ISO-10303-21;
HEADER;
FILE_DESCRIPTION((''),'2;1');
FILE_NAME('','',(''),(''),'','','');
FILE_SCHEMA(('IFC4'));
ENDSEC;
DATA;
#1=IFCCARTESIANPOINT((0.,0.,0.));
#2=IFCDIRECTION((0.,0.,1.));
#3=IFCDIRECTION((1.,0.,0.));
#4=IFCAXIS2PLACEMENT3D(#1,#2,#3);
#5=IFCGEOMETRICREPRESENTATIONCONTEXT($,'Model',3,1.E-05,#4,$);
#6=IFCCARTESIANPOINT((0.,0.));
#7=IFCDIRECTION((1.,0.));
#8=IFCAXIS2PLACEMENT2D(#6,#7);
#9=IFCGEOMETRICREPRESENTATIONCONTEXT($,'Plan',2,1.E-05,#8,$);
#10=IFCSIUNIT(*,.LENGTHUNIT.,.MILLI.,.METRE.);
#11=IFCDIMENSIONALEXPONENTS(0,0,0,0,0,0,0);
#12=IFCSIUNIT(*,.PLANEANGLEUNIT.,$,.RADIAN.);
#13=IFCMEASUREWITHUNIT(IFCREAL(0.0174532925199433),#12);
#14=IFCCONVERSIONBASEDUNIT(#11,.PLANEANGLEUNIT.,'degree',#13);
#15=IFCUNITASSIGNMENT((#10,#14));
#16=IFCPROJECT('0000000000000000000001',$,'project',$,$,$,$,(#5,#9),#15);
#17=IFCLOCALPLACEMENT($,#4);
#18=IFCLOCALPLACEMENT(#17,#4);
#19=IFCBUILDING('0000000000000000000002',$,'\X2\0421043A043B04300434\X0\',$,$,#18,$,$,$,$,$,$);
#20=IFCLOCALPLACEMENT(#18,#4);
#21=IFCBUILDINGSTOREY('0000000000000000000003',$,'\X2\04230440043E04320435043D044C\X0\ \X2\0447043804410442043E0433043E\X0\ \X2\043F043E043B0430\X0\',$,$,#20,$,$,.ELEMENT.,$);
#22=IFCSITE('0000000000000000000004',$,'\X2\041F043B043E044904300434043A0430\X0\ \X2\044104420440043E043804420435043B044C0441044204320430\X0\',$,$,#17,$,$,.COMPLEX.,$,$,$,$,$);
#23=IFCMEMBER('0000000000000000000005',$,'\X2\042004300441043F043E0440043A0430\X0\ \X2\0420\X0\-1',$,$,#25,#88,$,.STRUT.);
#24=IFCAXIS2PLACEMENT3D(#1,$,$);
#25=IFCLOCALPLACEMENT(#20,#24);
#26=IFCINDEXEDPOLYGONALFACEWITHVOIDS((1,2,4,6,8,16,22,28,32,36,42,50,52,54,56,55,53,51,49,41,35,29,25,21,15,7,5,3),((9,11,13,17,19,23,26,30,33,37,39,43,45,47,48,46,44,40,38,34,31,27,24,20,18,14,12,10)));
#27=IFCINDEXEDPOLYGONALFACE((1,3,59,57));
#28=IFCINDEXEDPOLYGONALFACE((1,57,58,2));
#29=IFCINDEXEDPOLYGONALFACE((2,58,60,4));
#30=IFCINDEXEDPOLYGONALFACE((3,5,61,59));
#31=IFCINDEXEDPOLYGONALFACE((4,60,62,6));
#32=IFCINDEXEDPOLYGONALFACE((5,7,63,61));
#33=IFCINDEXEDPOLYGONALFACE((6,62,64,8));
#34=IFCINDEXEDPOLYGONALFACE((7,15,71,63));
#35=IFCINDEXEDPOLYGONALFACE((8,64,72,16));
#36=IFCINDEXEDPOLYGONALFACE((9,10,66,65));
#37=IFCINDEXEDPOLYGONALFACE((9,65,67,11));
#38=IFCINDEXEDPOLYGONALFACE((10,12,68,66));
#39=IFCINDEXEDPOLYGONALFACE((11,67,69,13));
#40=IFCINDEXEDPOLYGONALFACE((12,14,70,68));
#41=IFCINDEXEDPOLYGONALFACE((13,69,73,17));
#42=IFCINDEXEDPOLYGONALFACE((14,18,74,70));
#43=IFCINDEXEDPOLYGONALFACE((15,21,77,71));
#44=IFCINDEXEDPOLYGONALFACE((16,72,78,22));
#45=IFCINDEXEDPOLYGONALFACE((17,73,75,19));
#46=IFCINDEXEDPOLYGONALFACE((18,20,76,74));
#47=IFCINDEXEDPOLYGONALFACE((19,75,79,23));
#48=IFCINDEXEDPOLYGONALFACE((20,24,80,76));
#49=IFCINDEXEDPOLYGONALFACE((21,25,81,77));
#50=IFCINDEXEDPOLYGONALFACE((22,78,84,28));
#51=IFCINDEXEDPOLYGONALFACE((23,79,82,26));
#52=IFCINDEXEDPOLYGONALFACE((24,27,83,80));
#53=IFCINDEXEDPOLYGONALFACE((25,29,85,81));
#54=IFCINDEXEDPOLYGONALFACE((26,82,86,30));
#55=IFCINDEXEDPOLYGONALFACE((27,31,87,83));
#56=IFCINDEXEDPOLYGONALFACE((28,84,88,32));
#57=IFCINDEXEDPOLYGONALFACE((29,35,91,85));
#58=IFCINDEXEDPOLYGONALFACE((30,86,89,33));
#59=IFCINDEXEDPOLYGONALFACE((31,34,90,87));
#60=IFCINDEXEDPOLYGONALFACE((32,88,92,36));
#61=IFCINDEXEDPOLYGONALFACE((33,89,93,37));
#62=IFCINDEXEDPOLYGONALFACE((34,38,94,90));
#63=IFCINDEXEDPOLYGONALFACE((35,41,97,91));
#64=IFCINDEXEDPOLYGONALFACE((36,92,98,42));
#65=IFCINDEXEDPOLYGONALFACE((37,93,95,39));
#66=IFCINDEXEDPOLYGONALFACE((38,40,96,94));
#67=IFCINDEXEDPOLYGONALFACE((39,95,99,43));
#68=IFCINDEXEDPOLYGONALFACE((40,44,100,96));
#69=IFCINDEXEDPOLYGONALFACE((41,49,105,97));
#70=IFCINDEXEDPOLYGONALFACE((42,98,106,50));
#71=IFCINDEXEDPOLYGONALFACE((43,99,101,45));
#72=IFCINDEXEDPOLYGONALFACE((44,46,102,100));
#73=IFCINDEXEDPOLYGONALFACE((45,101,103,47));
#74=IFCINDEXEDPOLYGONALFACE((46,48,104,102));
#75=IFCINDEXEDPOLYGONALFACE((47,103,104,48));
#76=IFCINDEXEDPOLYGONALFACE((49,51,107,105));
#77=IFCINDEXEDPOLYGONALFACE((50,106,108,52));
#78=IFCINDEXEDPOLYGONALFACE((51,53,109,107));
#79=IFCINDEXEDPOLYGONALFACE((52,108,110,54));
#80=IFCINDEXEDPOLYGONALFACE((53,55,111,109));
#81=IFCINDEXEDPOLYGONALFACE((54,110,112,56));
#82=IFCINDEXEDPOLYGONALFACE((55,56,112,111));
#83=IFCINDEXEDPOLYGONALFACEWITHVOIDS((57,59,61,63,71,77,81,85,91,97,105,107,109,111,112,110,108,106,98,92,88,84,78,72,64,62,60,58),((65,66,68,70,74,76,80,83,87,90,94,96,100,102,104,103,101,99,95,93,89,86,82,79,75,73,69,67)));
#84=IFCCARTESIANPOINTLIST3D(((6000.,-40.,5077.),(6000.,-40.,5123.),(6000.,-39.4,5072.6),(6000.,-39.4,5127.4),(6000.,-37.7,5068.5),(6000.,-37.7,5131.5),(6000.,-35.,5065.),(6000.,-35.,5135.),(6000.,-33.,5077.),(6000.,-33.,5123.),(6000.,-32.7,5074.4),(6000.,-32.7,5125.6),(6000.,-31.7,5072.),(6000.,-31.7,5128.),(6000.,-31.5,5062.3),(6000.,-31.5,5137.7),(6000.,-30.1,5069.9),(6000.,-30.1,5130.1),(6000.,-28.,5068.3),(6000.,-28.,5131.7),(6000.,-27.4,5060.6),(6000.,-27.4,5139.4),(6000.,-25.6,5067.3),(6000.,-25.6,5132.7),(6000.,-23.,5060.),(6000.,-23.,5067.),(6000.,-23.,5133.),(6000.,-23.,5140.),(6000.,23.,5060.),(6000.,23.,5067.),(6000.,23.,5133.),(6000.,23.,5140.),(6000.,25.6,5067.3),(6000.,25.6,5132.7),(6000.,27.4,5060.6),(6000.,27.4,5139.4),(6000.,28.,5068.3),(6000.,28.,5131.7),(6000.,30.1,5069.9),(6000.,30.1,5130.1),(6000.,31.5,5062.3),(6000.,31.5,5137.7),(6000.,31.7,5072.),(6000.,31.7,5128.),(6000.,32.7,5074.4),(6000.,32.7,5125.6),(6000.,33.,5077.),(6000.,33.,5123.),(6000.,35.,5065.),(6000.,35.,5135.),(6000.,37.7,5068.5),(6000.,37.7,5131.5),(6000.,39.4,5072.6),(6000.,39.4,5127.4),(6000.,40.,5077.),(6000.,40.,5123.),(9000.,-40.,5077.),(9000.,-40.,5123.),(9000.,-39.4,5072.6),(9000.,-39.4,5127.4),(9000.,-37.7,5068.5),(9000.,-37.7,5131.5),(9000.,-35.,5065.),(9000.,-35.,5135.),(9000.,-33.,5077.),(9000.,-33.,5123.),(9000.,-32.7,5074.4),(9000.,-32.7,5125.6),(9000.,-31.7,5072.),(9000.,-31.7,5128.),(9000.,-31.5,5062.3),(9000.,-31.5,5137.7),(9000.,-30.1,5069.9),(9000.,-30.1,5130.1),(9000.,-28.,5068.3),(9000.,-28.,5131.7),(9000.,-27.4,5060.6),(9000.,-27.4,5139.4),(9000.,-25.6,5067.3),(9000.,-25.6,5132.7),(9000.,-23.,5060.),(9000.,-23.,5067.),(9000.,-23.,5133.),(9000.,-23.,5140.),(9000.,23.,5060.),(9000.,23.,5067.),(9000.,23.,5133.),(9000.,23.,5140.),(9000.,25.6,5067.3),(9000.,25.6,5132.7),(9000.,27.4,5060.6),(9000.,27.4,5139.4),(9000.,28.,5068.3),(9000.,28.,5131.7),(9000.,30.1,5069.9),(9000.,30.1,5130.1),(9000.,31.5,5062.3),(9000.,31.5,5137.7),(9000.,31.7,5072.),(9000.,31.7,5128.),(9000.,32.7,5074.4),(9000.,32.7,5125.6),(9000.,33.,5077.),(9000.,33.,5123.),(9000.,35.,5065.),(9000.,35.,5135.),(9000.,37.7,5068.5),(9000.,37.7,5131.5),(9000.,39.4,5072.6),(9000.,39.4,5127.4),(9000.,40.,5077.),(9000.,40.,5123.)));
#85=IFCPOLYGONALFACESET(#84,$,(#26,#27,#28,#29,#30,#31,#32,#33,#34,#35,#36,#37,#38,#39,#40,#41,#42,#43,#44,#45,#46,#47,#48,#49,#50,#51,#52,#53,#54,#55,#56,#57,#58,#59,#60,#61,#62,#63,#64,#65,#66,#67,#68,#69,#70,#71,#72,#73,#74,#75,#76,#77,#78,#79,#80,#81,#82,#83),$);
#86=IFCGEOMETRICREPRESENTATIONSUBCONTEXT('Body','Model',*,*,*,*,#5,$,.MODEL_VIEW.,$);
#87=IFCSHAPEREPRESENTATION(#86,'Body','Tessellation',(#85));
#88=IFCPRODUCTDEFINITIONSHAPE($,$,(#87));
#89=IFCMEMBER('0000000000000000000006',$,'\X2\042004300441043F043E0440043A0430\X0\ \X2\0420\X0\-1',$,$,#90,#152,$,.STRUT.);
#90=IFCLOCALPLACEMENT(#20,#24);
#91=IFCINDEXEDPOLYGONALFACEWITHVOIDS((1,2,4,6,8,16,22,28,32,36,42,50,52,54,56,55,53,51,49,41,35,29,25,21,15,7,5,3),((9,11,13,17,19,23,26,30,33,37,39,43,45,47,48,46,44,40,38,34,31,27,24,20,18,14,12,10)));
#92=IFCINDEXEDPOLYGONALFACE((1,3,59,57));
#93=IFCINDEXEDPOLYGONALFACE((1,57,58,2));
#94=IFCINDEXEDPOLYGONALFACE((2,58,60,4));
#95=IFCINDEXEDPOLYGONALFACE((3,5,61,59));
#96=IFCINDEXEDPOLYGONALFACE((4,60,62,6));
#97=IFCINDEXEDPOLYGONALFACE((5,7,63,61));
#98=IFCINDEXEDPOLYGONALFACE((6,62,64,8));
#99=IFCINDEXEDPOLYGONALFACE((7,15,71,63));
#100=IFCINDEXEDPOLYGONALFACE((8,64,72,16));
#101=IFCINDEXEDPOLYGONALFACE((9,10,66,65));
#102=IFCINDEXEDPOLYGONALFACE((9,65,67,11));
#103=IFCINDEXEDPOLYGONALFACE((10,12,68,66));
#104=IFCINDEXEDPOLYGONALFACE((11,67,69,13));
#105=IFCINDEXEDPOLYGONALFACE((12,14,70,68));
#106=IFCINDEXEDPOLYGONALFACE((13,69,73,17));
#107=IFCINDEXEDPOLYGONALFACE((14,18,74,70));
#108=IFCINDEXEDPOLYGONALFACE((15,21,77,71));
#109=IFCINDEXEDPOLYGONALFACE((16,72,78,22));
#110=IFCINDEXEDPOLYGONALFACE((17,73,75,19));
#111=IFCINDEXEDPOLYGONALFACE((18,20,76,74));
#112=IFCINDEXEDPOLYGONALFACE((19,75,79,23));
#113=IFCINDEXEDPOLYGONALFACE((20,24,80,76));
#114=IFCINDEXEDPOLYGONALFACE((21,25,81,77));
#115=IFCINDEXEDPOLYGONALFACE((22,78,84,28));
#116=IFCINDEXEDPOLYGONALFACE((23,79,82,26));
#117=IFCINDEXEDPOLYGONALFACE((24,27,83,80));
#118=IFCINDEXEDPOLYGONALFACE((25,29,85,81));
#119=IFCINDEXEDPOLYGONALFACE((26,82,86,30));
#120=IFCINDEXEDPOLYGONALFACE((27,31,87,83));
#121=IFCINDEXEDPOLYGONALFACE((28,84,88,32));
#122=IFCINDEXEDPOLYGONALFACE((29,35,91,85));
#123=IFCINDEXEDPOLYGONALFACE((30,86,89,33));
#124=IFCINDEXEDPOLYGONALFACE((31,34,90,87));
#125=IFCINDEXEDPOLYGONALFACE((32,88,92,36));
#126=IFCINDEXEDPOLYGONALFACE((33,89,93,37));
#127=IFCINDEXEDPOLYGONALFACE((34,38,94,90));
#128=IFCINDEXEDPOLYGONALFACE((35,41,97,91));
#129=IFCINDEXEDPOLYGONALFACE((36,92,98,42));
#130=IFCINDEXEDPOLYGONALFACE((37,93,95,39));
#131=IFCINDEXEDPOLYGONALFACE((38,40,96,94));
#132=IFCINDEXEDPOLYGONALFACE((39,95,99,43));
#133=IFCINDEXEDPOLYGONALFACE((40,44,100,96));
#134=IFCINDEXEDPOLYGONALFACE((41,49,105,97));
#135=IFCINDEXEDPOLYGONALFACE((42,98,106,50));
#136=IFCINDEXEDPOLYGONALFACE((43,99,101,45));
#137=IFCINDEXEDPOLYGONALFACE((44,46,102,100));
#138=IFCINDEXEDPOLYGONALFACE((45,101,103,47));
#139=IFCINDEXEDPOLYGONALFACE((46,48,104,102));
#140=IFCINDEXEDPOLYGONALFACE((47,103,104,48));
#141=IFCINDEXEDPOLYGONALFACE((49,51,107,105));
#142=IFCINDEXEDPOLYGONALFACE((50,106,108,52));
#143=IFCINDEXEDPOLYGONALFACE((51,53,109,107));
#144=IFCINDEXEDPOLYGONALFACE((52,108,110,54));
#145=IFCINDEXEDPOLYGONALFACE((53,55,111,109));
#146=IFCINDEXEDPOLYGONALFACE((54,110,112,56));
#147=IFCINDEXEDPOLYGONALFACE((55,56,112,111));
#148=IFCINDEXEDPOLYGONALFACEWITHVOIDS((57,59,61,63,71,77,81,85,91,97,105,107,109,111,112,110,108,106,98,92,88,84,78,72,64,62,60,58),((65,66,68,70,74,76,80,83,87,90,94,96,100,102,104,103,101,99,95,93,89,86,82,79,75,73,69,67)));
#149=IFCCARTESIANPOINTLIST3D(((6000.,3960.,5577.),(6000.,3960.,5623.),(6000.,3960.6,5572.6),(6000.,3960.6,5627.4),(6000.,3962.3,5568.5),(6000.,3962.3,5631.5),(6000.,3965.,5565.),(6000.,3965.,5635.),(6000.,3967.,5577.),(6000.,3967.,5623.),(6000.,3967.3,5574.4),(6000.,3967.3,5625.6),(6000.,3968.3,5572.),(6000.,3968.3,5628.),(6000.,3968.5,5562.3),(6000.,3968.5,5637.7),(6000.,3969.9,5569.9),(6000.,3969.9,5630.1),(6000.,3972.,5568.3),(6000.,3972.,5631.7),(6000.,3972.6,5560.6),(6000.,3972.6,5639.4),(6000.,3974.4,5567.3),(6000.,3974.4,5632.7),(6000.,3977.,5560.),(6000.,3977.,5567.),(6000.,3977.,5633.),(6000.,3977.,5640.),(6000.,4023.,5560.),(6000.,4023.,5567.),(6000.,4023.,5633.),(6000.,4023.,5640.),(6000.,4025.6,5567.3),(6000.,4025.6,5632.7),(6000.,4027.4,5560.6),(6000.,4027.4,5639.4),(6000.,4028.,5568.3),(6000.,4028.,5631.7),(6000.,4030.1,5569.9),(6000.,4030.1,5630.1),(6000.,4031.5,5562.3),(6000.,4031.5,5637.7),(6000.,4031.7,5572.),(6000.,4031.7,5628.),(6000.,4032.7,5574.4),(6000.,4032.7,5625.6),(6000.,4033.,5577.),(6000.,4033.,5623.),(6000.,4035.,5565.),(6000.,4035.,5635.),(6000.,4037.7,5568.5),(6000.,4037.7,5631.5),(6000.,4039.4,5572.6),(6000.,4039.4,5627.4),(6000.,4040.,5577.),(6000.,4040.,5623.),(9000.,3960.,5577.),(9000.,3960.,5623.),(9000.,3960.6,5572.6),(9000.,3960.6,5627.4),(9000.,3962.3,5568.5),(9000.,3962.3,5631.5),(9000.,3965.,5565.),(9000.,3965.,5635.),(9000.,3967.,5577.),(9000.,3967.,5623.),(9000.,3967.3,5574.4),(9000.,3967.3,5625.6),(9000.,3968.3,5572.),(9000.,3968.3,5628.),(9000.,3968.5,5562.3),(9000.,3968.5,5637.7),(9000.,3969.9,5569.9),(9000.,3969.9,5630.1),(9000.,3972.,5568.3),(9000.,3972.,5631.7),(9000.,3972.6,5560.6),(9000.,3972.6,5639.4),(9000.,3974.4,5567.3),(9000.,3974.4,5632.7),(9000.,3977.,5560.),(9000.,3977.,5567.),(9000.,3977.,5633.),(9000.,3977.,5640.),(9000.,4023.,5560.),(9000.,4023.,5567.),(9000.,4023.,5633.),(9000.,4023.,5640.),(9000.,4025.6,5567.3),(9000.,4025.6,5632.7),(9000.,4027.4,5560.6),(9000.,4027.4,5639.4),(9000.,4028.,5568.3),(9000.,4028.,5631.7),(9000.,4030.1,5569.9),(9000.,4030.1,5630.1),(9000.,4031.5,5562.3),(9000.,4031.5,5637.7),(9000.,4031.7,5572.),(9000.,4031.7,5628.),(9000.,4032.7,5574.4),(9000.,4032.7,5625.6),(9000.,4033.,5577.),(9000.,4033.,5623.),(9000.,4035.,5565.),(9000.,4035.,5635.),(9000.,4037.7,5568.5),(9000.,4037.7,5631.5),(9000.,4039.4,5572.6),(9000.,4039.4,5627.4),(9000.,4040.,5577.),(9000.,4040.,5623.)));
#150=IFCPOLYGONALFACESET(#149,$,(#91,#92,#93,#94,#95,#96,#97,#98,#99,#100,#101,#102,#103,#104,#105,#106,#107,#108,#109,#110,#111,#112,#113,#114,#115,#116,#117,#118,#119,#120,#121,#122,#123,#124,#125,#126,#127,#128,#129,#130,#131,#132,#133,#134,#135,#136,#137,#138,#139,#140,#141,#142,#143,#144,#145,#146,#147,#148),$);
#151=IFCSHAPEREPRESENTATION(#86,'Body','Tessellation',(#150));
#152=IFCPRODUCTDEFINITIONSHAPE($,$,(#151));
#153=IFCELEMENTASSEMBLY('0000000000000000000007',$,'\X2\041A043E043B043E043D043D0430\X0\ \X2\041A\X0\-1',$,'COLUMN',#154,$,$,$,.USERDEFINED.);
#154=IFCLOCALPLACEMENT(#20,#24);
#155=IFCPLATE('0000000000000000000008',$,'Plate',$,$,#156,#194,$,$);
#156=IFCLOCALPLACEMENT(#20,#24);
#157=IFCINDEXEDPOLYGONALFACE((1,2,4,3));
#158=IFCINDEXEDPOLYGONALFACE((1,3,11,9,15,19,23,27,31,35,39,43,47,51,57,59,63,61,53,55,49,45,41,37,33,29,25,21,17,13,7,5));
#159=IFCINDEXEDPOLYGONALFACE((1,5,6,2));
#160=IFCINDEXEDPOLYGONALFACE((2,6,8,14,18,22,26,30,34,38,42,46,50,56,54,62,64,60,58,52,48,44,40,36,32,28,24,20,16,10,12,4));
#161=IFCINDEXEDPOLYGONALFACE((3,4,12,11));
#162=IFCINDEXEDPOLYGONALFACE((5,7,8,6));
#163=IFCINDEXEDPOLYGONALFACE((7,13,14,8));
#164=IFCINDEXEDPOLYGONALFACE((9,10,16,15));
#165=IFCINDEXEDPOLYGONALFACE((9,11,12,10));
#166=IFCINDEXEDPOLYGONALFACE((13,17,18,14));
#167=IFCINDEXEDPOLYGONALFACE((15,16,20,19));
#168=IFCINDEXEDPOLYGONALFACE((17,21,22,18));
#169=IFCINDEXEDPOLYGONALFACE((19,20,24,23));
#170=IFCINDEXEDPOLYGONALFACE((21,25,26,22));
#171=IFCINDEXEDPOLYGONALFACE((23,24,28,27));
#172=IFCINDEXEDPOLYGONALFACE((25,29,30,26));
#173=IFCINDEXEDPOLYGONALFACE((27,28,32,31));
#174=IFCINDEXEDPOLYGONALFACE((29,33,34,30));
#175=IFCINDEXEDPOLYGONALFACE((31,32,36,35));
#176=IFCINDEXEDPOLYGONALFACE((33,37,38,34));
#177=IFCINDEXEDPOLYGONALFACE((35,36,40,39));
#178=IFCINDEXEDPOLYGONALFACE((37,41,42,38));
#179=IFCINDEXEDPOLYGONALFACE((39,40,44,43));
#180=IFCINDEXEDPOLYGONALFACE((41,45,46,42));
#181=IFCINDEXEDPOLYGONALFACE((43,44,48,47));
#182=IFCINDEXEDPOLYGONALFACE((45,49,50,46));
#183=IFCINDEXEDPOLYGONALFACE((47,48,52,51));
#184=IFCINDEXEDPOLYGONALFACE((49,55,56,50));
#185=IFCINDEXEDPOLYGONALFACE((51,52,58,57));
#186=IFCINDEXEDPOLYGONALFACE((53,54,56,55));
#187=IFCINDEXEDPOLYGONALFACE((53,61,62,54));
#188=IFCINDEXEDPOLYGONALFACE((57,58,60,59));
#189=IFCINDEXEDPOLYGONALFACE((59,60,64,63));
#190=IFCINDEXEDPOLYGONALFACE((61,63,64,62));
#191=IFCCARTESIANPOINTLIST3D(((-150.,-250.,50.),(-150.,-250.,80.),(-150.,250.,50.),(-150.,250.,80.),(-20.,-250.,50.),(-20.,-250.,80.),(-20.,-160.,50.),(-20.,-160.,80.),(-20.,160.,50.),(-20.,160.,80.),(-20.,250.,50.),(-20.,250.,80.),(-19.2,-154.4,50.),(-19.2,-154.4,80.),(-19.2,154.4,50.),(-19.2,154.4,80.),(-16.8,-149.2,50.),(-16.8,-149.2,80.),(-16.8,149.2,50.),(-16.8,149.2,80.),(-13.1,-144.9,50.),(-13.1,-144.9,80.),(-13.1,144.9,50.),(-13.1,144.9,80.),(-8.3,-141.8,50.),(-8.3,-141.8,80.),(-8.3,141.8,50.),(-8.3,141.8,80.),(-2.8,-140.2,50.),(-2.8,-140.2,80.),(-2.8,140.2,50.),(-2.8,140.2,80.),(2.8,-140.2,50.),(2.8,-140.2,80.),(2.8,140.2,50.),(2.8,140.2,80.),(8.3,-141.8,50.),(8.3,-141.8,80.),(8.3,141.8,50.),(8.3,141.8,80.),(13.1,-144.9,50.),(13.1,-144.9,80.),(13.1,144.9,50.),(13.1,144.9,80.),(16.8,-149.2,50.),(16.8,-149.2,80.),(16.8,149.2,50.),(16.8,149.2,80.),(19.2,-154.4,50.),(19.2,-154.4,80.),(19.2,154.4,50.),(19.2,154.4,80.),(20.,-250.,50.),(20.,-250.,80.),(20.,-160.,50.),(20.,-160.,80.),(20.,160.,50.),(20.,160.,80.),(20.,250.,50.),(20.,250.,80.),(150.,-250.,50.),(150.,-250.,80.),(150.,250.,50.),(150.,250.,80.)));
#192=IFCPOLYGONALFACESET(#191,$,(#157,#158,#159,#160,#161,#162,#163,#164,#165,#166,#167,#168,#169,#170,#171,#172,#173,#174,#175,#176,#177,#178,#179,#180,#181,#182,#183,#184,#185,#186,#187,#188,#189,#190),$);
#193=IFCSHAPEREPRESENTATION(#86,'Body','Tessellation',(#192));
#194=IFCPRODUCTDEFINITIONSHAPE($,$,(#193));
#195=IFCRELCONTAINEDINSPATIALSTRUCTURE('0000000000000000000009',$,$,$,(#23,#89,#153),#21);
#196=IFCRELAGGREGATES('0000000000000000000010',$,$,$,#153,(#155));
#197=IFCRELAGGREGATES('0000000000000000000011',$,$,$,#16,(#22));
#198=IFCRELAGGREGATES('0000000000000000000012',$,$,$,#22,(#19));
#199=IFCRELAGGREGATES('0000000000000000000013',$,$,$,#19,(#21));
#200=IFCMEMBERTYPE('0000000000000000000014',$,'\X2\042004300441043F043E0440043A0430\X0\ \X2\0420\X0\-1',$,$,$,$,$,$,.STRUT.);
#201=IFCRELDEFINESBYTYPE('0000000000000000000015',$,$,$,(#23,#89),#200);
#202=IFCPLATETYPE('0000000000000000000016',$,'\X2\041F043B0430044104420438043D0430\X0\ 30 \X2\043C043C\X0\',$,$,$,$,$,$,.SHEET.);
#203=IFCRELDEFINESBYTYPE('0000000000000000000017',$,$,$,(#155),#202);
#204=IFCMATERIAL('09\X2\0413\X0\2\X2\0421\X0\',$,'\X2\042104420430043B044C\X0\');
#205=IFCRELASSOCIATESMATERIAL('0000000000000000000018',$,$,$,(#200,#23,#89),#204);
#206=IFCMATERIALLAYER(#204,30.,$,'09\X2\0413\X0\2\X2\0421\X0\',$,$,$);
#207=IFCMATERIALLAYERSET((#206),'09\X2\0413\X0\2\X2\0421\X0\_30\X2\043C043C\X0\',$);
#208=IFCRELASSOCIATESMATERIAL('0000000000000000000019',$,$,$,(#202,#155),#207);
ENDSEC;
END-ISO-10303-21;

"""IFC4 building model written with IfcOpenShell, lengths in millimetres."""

from ifc_helpers import new_model, entity, si_unit, converted_unit, frame, origin_with_axes, origin_2d_with_axis, place, context, subcontext, project, spatial, line, arc, indexed_curve, hollow_rectangle, outline, extrude, material, layer, layer_set, layer_usage, material_profile, profile_set, profile_usage, type_object, element, aggregate, save


model = new_model("IFC4")

# Units and contexts
model_context = context("Model", 3, precision=1e-05, world=origin_with_axes())
plan_context = context("Plan", 2, precision=1e-05, world=origin_2d_with_axis())
body_context = subcontext(model_context, "Body", "Model", "MODEL_VIEW")
ifc_project = project(units=[si_unit("LENGTHUNIT", "METRE", prefix="MILLI"), converted_unit("PLANEANGLEUNIT", "degree", entity("IfcReal", 0.0174532925199433), si_unit("PLANEANGLEUNIT", "RADIAN"), dimensions=[0, 0, 0, 0, 0, 0, 0])], contexts=[model_context, plan_context])

# Site, building, storey
site_placement = place(None, origin_with_axes())
site = spatial("IfcSite", under=ifc_project, at=site_placement, Name="Площадка строительства", CompositionType="COMPLEX")
building_placement = place(site_placement, origin_with_axes())
building = spatial("IfcBuilding", under=site, at=building_placement, Name="Склад")
storey_placement = place(building_placement, origin_with_axes())
storey = spatial("IfcBuildingStorey", under=building, at=storey_placement, Name="Уровень чистого пола", CompositionType="ELEMENT")

# Members
ifc_material_1 = material(Name="09Г2С", Category="Сталь")
ifc_material_profile_1 = material_profile(ifc_material_1, hollow_rectangle(XDim=80.0, YDim=80.0, WallThickness=7.0, InnerFilletRadius=10.0, OuterFilletRadius=17.0))
ifc_profile_set_1 = profile_set([ifc_material_profile_1], Name="PK80x7_09G2S")
member_type_1 = type_object("IfcMemberType", Name="Распорка Р-1", PredefinedType="STRUT", material=ifc_profile_set_1)
ifc_profile_usage_1 = profile_usage(ifc_profile_set_1, cardinal=5)
member_1_placement = place(storey_placement, frame((6000.0, 0.0, 5100.0), z_axis=(1.0, 0.0, 0.0), x_axis=(0.0, 1.0, 0.0)))
element("IfcMember", 1, at=member_1_placement, inside=storey, type_object=member_type_1, material=ifc_profile_usage_1, Name="Распорка Р-1", PredefinedType="STRUT", context=body_context, shape_type="SweptSolid", body=[
    extrude(hollow_rectangle(XDim=80.0, YDim=80.0, WallThickness=7.0, InnerFilletRadius=10.0, OuterFilletRadius=17.0), origin_with_axes(), (0.0, 0.0, 1.0), 3000.0),
])
ifc_profile_usage_2 = profile_usage(ifc_profile_set_1, cardinal=5)
member_2_placement = place(storey_placement, frame((6000.0, 4000.0, 5600.0), z_axis=(1.0, 0.0, 0.0), x_axis=(0.0, 1.0, 0.0)))
element("IfcMember", 2, at=member_2_placement, inside=storey, type_object=member_type_1, material=ifc_profile_usage_2, Name="Распорка Р-1", PredefinedType="STRUT", context=body_context, shape_type="SweptSolid", body=[
    extrude(hollow_rectangle(XDim=80.0, YDim=80.0, WallThickness=7.0, InnerFilletRadius=10.0, OuterFilletRadius=17.0), origin_with_axes(), (0.0, 0.0, 1.0), 3000.0),
])

# Element assembly, plate
assembly_placement = place(storey_placement, origin_with_axes())
assembly = element("IfcElementAssembly", 3, at=assembly_placement, inside=storey, Name="Колонна К-1", ObjectType="COLUMN", PredefinedType="USERDEFINED")
ifc_layer = layer(ifc_material_1, 30.0, Name="09Г2С")
ifc_layer_set = layer_set([ifc_layer], Name="09Г2С_30мм")
ifc_layer_usage = layer_usage(ifc_layer_set, "AXIS3", "POSITIVE", 0.0)
plate_type = type_object("IfcPlateType", Name="Пластина 30 мм", PredefinedType="SHEET", material=ifc_layer_set)
plate_placement = place(assembly_placement, frame((0.0, 0.0, 50.0), z_axis=(0.0, 0.0, 1.0), x_axis=(1.0, 0.0, 0.0)))
plate = element("IfcPlate", 4, at=plate_placement, type_object=plate_type, material=ifc_layer_usage, Name="Plate", context=body_context, shape_type="SweptSolid", body=[
    extrude(outline(indexed_curve([(-20.0, -250.0), (-150.0, -250.0), (-150.0, 250.0), (150.0, 250.0), (150.0, -250.0), (20.0, -250.0), (20.0, -160.0), (0.0, -140.0), (-20.0, -160.0), (20.0, 250.0), (-20.0, 250.0), (-20.0, 160.0), (0.0, 140.0), (20.0, 160.0)], segments=[line(5, 4), line(4, 10), line(10, 14), arc(14, 13, 12), line(12, 11), line(11, 3), line(3, 2), line(2, 1), line(1, 9), arc(9, 8, 7), line(7, 6), line(6, 5)], self_intersect=False)), None, (0.0, 0.0, 1.0), 30.0),
])
aggregate(assembly, [plate])

save(model, "model.ifc")
